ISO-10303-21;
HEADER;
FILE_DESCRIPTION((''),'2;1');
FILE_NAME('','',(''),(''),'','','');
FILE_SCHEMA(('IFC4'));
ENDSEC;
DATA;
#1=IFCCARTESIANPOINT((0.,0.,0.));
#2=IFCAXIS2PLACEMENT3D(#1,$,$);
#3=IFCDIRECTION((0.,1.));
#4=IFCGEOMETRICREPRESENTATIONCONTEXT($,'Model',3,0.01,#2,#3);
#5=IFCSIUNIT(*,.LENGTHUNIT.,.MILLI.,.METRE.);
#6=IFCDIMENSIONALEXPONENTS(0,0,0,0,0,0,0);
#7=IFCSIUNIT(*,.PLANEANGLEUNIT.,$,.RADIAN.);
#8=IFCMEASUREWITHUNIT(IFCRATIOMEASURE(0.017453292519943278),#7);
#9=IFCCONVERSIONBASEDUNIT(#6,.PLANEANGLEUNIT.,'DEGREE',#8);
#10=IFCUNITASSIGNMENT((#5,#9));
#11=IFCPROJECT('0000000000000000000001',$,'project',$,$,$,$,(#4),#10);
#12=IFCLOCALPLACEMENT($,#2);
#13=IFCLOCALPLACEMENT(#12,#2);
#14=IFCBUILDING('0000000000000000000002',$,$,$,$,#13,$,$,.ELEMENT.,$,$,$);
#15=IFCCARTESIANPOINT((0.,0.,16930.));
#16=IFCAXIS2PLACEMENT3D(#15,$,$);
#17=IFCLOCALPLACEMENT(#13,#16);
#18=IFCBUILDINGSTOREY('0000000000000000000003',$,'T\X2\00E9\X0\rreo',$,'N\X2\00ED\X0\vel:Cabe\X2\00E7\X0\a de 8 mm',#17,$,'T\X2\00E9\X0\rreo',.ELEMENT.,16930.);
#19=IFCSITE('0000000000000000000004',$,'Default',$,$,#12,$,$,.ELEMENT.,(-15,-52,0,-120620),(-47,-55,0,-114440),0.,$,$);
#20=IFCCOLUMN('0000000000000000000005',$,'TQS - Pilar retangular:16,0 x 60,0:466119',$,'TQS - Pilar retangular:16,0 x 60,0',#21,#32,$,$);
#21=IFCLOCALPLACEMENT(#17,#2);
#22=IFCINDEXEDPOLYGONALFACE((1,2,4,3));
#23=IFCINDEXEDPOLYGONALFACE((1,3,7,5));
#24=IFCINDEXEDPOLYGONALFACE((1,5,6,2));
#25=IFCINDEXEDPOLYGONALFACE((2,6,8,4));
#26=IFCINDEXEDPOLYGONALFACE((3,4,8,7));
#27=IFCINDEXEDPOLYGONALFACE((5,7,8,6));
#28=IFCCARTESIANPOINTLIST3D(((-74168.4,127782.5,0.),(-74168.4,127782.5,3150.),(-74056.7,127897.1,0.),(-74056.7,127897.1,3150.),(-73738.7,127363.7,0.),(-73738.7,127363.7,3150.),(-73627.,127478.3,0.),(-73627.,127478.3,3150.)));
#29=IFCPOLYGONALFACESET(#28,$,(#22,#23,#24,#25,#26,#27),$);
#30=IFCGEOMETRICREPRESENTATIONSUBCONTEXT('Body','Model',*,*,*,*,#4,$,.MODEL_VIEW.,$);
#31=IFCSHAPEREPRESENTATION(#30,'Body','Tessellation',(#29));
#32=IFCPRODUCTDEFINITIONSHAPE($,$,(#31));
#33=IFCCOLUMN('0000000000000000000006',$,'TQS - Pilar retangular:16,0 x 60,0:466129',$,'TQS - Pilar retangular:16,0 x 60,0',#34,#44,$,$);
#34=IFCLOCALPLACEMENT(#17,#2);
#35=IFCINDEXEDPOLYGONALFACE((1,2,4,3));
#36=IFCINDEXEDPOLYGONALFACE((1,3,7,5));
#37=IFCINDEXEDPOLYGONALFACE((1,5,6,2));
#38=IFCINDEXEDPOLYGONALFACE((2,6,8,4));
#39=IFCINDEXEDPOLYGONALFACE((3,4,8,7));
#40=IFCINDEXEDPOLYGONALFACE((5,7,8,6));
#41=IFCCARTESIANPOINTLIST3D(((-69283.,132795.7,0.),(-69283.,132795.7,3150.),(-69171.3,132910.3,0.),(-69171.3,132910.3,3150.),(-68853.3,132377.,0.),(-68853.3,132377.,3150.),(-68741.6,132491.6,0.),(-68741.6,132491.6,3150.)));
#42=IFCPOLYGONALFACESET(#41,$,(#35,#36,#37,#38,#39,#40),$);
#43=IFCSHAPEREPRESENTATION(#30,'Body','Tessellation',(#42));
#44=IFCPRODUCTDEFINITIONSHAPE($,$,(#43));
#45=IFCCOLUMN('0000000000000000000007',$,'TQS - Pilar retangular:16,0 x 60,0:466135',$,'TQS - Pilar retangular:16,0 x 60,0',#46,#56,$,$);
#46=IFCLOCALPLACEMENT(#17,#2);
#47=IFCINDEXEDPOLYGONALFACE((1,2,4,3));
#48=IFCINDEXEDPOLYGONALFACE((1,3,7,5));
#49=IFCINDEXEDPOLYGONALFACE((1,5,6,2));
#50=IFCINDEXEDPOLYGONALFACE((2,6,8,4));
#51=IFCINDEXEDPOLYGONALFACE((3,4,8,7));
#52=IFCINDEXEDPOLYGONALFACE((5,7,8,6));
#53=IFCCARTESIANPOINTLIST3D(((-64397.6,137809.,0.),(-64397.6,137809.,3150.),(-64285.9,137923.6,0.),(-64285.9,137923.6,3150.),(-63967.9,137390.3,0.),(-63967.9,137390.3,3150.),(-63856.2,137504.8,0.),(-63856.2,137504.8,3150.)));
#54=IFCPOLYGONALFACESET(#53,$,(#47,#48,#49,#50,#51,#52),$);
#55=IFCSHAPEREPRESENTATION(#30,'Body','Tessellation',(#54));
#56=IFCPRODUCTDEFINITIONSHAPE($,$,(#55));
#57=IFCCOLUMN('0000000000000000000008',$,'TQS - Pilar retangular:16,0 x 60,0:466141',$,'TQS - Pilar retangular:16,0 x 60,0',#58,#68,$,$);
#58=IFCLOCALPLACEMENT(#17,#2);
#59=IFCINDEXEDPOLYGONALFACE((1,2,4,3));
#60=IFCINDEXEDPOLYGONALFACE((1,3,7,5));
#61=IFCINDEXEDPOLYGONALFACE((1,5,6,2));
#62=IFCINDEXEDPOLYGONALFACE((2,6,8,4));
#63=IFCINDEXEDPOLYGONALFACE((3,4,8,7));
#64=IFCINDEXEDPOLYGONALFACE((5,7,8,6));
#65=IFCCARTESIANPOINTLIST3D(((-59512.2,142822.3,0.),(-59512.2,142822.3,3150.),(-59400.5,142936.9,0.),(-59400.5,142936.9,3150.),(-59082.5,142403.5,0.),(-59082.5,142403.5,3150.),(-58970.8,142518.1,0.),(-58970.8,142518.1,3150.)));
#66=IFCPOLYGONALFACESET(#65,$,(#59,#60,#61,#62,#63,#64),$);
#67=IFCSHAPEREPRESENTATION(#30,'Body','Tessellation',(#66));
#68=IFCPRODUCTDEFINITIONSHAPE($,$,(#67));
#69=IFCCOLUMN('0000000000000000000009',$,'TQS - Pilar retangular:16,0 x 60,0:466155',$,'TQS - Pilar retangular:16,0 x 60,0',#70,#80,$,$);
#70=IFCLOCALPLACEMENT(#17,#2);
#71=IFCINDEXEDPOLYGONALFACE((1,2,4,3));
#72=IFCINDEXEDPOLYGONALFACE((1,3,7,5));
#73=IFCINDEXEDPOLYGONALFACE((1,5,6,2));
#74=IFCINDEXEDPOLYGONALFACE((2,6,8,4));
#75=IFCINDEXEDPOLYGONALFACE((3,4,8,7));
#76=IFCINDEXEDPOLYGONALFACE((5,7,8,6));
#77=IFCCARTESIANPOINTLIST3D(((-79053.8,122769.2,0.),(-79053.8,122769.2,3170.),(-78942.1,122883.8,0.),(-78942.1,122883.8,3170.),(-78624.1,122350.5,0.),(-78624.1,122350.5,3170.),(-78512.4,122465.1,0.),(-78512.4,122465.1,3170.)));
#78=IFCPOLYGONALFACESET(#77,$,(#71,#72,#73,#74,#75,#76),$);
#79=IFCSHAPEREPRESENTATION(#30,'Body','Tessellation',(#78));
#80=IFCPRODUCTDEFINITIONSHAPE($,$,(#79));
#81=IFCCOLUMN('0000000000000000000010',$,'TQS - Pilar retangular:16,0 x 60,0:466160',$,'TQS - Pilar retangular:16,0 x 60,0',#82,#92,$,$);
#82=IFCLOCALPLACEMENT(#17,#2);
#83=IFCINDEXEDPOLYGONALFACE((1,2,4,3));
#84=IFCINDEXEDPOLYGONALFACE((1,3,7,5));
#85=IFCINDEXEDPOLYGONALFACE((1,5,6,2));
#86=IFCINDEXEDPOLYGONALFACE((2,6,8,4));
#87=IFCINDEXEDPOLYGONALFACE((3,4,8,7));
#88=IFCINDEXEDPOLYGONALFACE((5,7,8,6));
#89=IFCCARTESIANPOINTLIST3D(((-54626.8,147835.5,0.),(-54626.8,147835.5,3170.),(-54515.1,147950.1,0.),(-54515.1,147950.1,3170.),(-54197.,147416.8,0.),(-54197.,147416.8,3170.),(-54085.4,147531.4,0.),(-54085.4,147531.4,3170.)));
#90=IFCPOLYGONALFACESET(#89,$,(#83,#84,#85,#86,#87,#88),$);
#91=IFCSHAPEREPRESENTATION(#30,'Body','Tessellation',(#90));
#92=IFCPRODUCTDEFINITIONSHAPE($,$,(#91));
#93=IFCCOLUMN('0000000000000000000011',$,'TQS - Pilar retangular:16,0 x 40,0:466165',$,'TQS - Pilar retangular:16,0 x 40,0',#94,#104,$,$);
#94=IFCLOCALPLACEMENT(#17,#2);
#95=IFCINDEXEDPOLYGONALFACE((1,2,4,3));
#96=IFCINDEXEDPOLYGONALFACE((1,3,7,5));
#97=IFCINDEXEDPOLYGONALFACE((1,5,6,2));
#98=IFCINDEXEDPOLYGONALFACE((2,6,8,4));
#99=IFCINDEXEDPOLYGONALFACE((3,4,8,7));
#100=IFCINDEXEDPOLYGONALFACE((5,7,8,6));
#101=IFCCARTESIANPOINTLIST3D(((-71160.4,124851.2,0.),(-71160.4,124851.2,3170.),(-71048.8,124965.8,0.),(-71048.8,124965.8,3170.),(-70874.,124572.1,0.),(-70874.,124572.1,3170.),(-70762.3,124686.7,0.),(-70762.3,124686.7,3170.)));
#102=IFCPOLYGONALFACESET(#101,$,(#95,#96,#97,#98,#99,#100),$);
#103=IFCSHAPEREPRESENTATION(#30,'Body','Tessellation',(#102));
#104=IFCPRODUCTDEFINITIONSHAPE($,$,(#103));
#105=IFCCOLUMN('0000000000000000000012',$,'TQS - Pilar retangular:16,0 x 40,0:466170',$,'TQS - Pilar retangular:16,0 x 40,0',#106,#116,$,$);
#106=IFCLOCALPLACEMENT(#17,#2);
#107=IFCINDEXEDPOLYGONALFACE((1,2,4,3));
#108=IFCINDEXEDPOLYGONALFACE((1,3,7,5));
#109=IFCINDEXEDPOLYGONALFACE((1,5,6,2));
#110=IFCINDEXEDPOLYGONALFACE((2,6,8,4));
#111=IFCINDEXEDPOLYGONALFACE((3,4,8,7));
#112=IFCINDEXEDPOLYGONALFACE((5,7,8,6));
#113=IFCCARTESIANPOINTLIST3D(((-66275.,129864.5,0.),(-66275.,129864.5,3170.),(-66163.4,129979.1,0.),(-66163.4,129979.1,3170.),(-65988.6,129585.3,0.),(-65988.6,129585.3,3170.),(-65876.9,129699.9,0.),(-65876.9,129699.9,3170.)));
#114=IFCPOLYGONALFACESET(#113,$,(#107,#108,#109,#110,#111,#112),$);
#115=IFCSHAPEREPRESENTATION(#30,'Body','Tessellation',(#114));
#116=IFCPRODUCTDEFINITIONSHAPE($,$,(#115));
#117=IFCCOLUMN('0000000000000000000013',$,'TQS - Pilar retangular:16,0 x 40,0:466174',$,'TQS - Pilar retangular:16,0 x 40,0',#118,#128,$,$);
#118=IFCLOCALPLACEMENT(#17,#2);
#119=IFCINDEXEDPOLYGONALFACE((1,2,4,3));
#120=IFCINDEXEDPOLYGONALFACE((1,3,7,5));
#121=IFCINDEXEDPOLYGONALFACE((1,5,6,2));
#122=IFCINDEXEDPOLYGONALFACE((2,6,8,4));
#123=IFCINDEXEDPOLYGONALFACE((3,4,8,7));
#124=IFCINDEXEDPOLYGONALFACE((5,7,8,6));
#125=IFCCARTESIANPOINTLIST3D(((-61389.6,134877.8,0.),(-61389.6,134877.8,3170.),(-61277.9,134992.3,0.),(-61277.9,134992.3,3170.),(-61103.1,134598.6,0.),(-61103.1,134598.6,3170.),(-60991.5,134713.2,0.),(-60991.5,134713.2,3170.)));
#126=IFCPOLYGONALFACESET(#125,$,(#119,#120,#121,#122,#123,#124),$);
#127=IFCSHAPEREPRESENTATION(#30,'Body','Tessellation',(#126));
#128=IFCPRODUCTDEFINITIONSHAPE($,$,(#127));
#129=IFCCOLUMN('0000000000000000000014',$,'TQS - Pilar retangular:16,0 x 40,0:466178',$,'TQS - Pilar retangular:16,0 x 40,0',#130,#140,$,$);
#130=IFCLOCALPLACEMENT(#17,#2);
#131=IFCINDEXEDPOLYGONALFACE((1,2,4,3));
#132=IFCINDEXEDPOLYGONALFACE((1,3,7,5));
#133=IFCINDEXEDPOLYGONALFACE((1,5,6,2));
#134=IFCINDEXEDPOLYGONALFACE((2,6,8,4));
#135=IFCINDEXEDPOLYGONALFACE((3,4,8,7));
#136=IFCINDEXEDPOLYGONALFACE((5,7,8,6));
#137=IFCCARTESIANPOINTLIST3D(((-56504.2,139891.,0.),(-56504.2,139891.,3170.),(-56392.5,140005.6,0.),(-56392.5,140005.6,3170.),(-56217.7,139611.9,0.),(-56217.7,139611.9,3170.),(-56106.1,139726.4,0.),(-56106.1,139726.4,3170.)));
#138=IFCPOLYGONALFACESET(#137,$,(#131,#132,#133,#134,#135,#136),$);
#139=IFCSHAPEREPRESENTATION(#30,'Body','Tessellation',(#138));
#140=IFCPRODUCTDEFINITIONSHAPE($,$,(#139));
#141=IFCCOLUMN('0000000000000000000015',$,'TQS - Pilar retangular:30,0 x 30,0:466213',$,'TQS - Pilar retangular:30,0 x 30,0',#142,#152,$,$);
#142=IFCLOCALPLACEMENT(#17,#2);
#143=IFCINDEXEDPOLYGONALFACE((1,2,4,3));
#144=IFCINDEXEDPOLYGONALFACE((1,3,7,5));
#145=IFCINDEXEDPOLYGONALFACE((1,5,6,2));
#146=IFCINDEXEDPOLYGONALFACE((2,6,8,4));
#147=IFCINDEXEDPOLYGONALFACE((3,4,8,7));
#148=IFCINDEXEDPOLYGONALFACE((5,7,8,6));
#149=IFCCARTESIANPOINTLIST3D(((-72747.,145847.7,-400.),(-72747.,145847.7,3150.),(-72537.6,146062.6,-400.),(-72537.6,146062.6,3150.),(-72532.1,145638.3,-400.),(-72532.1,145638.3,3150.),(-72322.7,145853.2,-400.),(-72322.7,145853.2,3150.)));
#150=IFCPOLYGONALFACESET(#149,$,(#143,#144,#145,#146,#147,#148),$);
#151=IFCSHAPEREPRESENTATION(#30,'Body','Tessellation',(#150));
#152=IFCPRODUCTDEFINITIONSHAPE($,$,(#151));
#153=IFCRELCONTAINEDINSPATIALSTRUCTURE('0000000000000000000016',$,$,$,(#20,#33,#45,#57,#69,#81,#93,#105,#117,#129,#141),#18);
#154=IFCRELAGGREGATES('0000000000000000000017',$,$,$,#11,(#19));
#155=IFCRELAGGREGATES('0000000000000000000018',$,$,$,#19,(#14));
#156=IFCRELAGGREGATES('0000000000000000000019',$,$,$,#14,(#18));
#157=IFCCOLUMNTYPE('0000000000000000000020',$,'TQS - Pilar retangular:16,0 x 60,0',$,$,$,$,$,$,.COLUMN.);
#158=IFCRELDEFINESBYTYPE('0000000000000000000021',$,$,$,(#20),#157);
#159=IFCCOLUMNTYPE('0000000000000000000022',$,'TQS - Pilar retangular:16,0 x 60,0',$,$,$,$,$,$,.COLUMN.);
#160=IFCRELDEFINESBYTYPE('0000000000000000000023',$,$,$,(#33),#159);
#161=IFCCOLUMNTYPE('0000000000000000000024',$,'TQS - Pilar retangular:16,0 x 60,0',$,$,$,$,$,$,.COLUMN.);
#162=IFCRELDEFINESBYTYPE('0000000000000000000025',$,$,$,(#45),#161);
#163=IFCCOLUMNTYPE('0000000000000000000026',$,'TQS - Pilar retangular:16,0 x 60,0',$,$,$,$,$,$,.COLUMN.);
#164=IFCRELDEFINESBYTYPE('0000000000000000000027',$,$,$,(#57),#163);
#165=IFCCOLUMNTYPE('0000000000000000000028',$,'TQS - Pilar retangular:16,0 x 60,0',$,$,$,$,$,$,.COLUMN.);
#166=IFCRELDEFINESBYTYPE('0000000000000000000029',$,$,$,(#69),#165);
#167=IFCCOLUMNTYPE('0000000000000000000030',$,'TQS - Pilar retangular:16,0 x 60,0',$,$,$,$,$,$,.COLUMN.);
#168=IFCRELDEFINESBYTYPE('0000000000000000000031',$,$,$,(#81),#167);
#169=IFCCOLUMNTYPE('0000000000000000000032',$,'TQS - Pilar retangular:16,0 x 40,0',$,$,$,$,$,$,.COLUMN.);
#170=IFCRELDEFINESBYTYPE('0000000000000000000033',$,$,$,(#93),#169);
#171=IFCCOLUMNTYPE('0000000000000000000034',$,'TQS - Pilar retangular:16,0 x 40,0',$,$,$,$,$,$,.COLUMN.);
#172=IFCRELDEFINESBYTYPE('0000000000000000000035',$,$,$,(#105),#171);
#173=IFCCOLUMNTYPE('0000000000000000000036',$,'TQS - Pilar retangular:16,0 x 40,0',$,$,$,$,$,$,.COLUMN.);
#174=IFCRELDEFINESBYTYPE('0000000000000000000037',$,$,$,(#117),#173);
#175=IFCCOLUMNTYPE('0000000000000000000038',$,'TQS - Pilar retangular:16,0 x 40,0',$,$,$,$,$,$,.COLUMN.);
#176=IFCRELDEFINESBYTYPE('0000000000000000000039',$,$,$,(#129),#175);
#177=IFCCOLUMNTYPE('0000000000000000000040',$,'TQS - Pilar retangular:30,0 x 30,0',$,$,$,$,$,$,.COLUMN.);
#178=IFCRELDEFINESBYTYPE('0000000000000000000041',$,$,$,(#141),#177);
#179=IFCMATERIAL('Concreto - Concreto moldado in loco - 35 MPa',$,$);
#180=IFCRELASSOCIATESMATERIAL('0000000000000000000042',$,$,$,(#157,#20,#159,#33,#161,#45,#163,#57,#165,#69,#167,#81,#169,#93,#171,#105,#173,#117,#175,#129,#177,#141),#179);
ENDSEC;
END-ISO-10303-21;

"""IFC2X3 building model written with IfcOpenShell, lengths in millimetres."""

from ifc_helpers import new_model, entity, si_unit, converted_unit, direction, frame, frame_2d, origin, origin_2d_with_axis, place, context, subcontext, project, spatial, rectangle, extrude, source, transform, mapped, material, type_object, type_shapes, element, save


model = new_model("IFC2X3")

# Units and contexts
model_context = context("Model", 3, precision=0.01, world=origin(), true_north=direction((0.0, 1.0)))
body_context = subcontext(model_context, "Body", "Model", "MODEL_VIEW")
ifc_project = project(units=[si_unit("LENGTHUNIT", "METRE", prefix="MILLI"), converted_unit("PLANEANGLEUNIT", "DEGREE", entity("IfcRatioMeasure", 0.017453292519943278), si_unit("PLANEANGLEUNIT", "RADIAN"), dimensions=[0, 0, 0, 0, 0, 0, 0])], contexts=[model_context])

# Site, building, storey
site_placement = place(None, origin())
site = spatial("IfcSite", under=ifc_project, at=site_placement, Name="Default", CompositionType="ELEMENT", RefLatitude=(-15, -52, 0, -120620), RefLongitude=(-47, -55, 0, -114440), RefElevation=0.0)
building_placement = place(site_placement, origin())
building = spatial("IfcBuilding", under=site, at=building_placement, CompositionType="ELEMENT")
storey_placement = place(building_placement, frame((0.0, 0.0, 16930.0)))
storey = spatial("IfcBuildingStorey", under=building, at=storey_placement, Name="Térreo", ObjectType="Nível:Cabeça de 8 mm", LongName="Térreo", CompositionType="ELEMENT", Elevation=16930.0)

# Columns
ifc_material = material(Name="Concreto - Concreto moldado in loco - 35 MPa")
column_type_1 = type_object("IfcColumnType", Name="TQS - Pilar retangular:16,0 x 60,0", PredefinedType="COLUMN", material=ifc_material)
shared_shape_1 = source(origin(), body_context, "Body", "SweptSolid", [
    extrude(rectangle(XDim=600.0, YDim=160.0, at=frame_2d((0.0, 0.0), x_axis=(1.0, 0.0))), frame((-73897.7, 127630.4, 16930.0), z_axis=(0.0, 0.0, 1.0), x_axis=(-0.71618, 0.697915, 0.0)), (0.0, 0.0, 1.0), 3150.0),
])
type_shapes(column_type_1, [shared_shape_1])
column_1_placement = place(storey_placement, frame((0.0, 0.0, -16930.0)))
element("IfcColumn", 1, at=column_1_placement, inside=storey, type_object=column_type_1, material=ifc_material, Name="TQS - Pilar retangular:16,0 x 60,0:466119", ObjectType="TQS - Pilar retangular:16,0 x 60,0", context=body_context, shape_type="MappedRepresentation", body=[
    mapped(shared_shape_1, transform((0.0, 0.0, 0.0), scale=1.0)),
])
column_type_2 = type_object("IfcColumnType", Name="TQS - Pilar retangular:16,0 x 60,0", PredefinedType="COLUMN", material=ifc_material)
shared_shape_2 = source(origin(), body_context, "Body", "SweptSolid", [
    extrude(rectangle(XDim=600.0, YDim=160.0, at=frame_2d((0.0, 0.0), x_axis=(1.0, 0.0))), frame((-69012.3, 132643.7, 16930.0), z_axis=(0.0, 0.0, 1.0), x_axis=(-0.71618, 0.697915, 0.0)), (0.0, 0.0, 1.0), 3150.0),
])
type_shapes(column_type_2, [shared_shape_2])
column_2_placement = place(storey_placement, frame((0.0, 0.0, -16930.0)))
element("IfcColumn", 2, at=column_2_placement, inside=storey, type_object=column_type_2, material=ifc_material, Name="TQS - Pilar retangular:16,0 x 60,0:466129", ObjectType="TQS - Pilar retangular:16,0 x 60,0", context=body_context, shape_type="MappedRepresentation", body=[
    mapped(shared_shape_2, transform((0.0, 0.0, 0.0), scale=1.0)),
])
column_type_3 = type_object("IfcColumnType", Name="TQS - Pilar retangular:16,0 x 60,0", PredefinedType="COLUMN", material=ifc_material)
shared_shape_3 = source(origin(), body_context, "Body", "SweptSolid", [
    extrude(rectangle(XDim=600.0, YDim=160.0, at=frame_2d((0.0, 0.0), x_axis=(1.0, 0.0))), frame((-64126.9, 137656.9, 16930.0), z_axis=(0.0, 0.0, 1.0), x_axis=(-0.71618, 0.697915, 0.0)), (0.0, 0.0, 1.0), 3150.0),
])
type_shapes(column_type_3, [shared_shape_3])
column_3_placement = place(storey_placement, frame((0.0, 0.0, -16930.0)))
element("IfcColumn", 3, at=column_3_placement, inside=storey, type_object=column_type_3, material=ifc_material, Name="TQS - Pilar retangular:16,0 x 60,0:466135", ObjectType="TQS - Pilar retangular:16,0 x 60,0", context=body_context, shape_type="MappedRepresentation", body=[
    mapped(shared_shape_3, transform((0.0, 0.0, 0.0), scale=1.0)),
])
column_type_4 = type_object("IfcColumnType", Name="TQS - Pilar retangular:16,0 x 60,0", PredefinedType="COLUMN", material=ifc_material)
shared_shape_4 = source(origin(), body_context, "Body", "SweptSolid", [
    extrude(rectangle(XDim=600.0, YDim=160.0, at=frame_2d((0.0, 0.0), x_axis=(1.0, 0.0))), frame((-59241.5, 142670.2, 16930.0), z_axis=(0.0, 0.0, 1.0), x_axis=(-0.71618, 0.697915, 0.0)), (0.0, 0.0, 1.0), 3150.0),
])
type_shapes(column_type_4, [shared_shape_4])
column_4_placement = place(storey_placement, frame((0.0, 0.0, -16930.0)))
element("IfcColumn", 4, at=column_4_placement, inside=storey, type_object=column_type_4, material=ifc_material, Name="TQS - Pilar retangular:16,0 x 60,0:466141", ObjectType="TQS - Pilar retangular:16,0 x 60,0", context=body_context, shape_type="MappedRepresentation", body=[
    mapped(shared_shape_4, transform((0.0, 0.0, 0.0), scale=1.0)),
])
column_type_5 = type_object("IfcColumnType", Name="TQS - Pilar retangular:16,0 x 60,0", PredefinedType="COLUMN", material=ifc_material)
shared_shape_5 = source(origin(), body_context, "Body", "SweptSolid", [
    extrude(rectangle(XDim=600.0, YDim=160.0, at=frame_2d((0.0, 0.0), x_axis=(1.0, 0.0))), frame((-78783.1, 122617.1, 16930.0), z_axis=(0.0, 0.0, 1.0), x_axis=(-0.71618, 0.697915, 0.0)), (0.0, 0.0, 1.0), 3170.0),
])
type_shapes(column_type_5, [shared_shape_5])
column_5_placement = place(storey_placement, frame((0.0, 0.0, -16930.0)))
element("IfcColumn", 5, at=column_5_placement, inside=storey, type_object=column_type_5, material=ifc_material, Name="TQS - Pilar retangular:16,0 x 60,0:466155", ObjectType="TQS - Pilar retangular:16,0 x 60,0", context=body_context, shape_type="MappedRepresentation", body=[
    mapped(shared_shape_5, transform((0.0, 0.0, 0.0), scale=1.0)),
])
column_type_6 = type_object("IfcColumnType", Name="TQS - Pilar retangular:16,0 x 60,0", PredefinedType="COLUMN", material=ifc_material)
shared_shape_6 = source(origin(), body_context, "Body", "SweptSolid", [
    extrude(rectangle(XDim=600.0, YDim=160.0, at=frame_2d((0.0, 0.0), x_axis=(1.0, 0.0))), frame((-54356.1, 147683.4, 16930.0), z_axis=(0.0, 0.0, 1.0), x_axis=(-0.71618, 0.697915, 0.0)), (0.0, 0.0, 1.0), 3170.0),
])
type_shapes(column_type_6, [shared_shape_6])
column_6_placement = place(storey_placement, frame((0.0, 0.0, -16930.0)))
element("IfcColumn", 6, at=column_6_placement, inside=storey, type_object=column_type_6, material=ifc_material, Name="TQS - Pilar retangular:16,0 x 60,0:466160", ObjectType="TQS - Pilar retangular:16,0 x 60,0", context=body_context, shape_type="MappedRepresentation", body=[
    mapped(shared_shape_6, transform((0.0, 0.0, 0.0), scale=1.0)),
])
column_type_7 = type_object("IfcColumnType", Name="TQS - Pilar retangular:16,0 x 40,0", PredefinedType="COLUMN", material=ifc_material)
shared_shape_7 = source(origin(), body_context, "Body", "SweptSolid", [
    extrude(rectangle(XDim=400.0, YDim=160.0, at=frame_2d((0.0, 0.0), x_axis=(1.0, 0.0))), frame((-70961.4, 124768.9, 16930.0), z_axis=(0.0, 0.0, 1.0), x_axis=(-0.71618, 0.697915, 0.0)), (0.0, 0.0, 1.0), 3170.0),
])
type_shapes(column_type_7, [shared_shape_7])
column_7_placement = place(storey_placement, frame((0.0, 0.0, -16930.0)))
element("IfcColumn", 7, at=column_7_placement, inside=storey, type_object=column_type_7, material=ifc_material, Name="TQS - Pilar retangular:16,0 x 40,0:466165", ObjectType="TQS - Pilar retangular:16,0 x 40,0", context=body_context, shape_type="MappedRepresentation", body=[
    mapped(shared_shape_7, transform((0.0, 0.0, 0.0), scale=1.0)),
])
column_type_8 = type_object("IfcColumnType", Name="TQS - Pilar retangular:16,0 x 40,0", PredefinedType="COLUMN", material=ifc_material)
shared_shape_8 = source(origin(), body_context, "Body", "SweptSolid", [
    extrude(rectangle(XDim=400.0, YDim=160.0, at=frame_2d((0.0, 0.0), x_axis=(1.0, 0.0))), frame((-66076.0, 129782.2, 16930.0), z_axis=(0.0, 0.0, 1.0), x_axis=(-0.71618, 0.697915, 0.0)), (0.0, 0.0, 1.0), 3170.0),
])
type_shapes(column_type_8, [shared_shape_8])
column_8_placement = place(storey_placement, frame((0.0, 0.0, -16930.0)))
element("IfcColumn", 8, at=column_8_placement, inside=storey, type_object=column_type_8, material=ifc_material, Name="TQS - Pilar retangular:16,0 x 40,0:466170", ObjectType="TQS - Pilar retangular:16,0 x 40,0", context=body_context, shape_type="MappedRepresentation", body=[
    mapped(shared_shape_8, transform((0.0, 0.0, 0.0), scale=1.0)),
])
column_type_9 = type_object("IfcColumnType", Name="TQS - Pilar retangular:16,0 x 40,0", PredefinedType="COLUMN", material=ifc_material)
shared_shape_9 = source(origin(), body_context, "Body", "SweptSolid", [
    extrude(rectangle(XDim=400.0, YDim=160.0, at=frame_2d((0.0, 0.0), x_axis=(1.0, 0.0))), frame((-61190.5, 134795.5, 16930.0), z_axis=(0.0, 0.0, 1.0), x_axis=(-0.71618, 0.697915, 0.0)), (0.0, 0.0, 1.0), 3170.0),
])
type_shapes(column_type_9, [shared_shape_9])
column_9_placement = place(storey_placement, frame((0.0, 0.0, -16930.0)))
element("IfcColumn", 9, at=column_9_placement, inside=storey, type_object=column_type_9, material=ifc_material, Name="TQS - Pilar retangular:16,0 x 40,0:466174", ObjectType="TQS - Pilar retangular:16,0 x 40,0", context=body_context, shape_type="MappedRepresentation", body=[
    mapped(shared_shape_9, transform((0.0, 0.0, 0.0), scale=1.0)),
])
column_type_10 = type_object("IfcColumnType", Name="TQS - Pilar retangular:16,0 x 40,0", PredefinedType="COLUMN", material=ifc_material)
shared_shape_10 = source(origin(), body_context, "Body", "SweptSolid", [
    extrude(rectangle(XDim=400.0, YDim=160.0, at=frame_2d((0.0, 0.0), x_axis=(1.0, 0.0))), frame((-56305.1, 139808.7, 16930.0), z_axis=(0.0, 0.0, 1.0), x_axis=(-0.71618, 0.697915, 0.0)), (0.0, 0.0, 1.0), 3170.0),
])
type_shapes(column_type_10, [shared_shape_10])
column_10_placement = place(storey_placement, frame((0.0, 0.0, -16930.0)))
element("IfcColumn", 10, at=column_10_placement, inside=storey, type_object=column_type_10, material=ifc_material, Name="TQS - Pilar retangular:16,0 x 40,0:466178", ObjectType="TQS - Pilar retangular:16,0 x 40,0", context=body_context, shape_type="MappedRepresentation", body=[
    mapped(shared_shape_10, transform((0.0, 0.0, 0.0), scale=1.0)),
])
column_type_11 = type_object("IfcColumnType", Name="TQS - Pilar retangular:30,0 x 30,0", PredefinedType="COLUMN", material=ifc_material)
shared_shape_11 = source(origin(), body_context, "Body", "SweptSolid", [
    extrude(rectangle(XDim=300.0, YDim=300.0, at=origin_2d_with_axis()), frame((-72534.8, 145850.5, 16530.0), z_axis=(0.0, 0.0, 1.0), x_axis=(-0.71618, 0.697915, 0.0)), (0.0, 0.0, 1.0), 3550.0),
])
type_shapes(column_type_11, [shared_shape_11])
column_11_placement = place(storey_placement, frame((0.0, 0.0, -16930.0)))
element("IfcColumn", 11, at=column_11_placement, inside=storey, type_object=column_type_11, material=ifc_material, Name="TQS - Pilar retangular:30,0 x 30,0:466213", ObjectType="TQS - Pilar retangular:30,0 x 30,0", context=body_context, shape_type="MappedRepresentation", body=[
    mapped(shared_shape_11, transform((0.0, 0.0, 0.0), scale=1.0)),
])

save(model, "model.ifc")
